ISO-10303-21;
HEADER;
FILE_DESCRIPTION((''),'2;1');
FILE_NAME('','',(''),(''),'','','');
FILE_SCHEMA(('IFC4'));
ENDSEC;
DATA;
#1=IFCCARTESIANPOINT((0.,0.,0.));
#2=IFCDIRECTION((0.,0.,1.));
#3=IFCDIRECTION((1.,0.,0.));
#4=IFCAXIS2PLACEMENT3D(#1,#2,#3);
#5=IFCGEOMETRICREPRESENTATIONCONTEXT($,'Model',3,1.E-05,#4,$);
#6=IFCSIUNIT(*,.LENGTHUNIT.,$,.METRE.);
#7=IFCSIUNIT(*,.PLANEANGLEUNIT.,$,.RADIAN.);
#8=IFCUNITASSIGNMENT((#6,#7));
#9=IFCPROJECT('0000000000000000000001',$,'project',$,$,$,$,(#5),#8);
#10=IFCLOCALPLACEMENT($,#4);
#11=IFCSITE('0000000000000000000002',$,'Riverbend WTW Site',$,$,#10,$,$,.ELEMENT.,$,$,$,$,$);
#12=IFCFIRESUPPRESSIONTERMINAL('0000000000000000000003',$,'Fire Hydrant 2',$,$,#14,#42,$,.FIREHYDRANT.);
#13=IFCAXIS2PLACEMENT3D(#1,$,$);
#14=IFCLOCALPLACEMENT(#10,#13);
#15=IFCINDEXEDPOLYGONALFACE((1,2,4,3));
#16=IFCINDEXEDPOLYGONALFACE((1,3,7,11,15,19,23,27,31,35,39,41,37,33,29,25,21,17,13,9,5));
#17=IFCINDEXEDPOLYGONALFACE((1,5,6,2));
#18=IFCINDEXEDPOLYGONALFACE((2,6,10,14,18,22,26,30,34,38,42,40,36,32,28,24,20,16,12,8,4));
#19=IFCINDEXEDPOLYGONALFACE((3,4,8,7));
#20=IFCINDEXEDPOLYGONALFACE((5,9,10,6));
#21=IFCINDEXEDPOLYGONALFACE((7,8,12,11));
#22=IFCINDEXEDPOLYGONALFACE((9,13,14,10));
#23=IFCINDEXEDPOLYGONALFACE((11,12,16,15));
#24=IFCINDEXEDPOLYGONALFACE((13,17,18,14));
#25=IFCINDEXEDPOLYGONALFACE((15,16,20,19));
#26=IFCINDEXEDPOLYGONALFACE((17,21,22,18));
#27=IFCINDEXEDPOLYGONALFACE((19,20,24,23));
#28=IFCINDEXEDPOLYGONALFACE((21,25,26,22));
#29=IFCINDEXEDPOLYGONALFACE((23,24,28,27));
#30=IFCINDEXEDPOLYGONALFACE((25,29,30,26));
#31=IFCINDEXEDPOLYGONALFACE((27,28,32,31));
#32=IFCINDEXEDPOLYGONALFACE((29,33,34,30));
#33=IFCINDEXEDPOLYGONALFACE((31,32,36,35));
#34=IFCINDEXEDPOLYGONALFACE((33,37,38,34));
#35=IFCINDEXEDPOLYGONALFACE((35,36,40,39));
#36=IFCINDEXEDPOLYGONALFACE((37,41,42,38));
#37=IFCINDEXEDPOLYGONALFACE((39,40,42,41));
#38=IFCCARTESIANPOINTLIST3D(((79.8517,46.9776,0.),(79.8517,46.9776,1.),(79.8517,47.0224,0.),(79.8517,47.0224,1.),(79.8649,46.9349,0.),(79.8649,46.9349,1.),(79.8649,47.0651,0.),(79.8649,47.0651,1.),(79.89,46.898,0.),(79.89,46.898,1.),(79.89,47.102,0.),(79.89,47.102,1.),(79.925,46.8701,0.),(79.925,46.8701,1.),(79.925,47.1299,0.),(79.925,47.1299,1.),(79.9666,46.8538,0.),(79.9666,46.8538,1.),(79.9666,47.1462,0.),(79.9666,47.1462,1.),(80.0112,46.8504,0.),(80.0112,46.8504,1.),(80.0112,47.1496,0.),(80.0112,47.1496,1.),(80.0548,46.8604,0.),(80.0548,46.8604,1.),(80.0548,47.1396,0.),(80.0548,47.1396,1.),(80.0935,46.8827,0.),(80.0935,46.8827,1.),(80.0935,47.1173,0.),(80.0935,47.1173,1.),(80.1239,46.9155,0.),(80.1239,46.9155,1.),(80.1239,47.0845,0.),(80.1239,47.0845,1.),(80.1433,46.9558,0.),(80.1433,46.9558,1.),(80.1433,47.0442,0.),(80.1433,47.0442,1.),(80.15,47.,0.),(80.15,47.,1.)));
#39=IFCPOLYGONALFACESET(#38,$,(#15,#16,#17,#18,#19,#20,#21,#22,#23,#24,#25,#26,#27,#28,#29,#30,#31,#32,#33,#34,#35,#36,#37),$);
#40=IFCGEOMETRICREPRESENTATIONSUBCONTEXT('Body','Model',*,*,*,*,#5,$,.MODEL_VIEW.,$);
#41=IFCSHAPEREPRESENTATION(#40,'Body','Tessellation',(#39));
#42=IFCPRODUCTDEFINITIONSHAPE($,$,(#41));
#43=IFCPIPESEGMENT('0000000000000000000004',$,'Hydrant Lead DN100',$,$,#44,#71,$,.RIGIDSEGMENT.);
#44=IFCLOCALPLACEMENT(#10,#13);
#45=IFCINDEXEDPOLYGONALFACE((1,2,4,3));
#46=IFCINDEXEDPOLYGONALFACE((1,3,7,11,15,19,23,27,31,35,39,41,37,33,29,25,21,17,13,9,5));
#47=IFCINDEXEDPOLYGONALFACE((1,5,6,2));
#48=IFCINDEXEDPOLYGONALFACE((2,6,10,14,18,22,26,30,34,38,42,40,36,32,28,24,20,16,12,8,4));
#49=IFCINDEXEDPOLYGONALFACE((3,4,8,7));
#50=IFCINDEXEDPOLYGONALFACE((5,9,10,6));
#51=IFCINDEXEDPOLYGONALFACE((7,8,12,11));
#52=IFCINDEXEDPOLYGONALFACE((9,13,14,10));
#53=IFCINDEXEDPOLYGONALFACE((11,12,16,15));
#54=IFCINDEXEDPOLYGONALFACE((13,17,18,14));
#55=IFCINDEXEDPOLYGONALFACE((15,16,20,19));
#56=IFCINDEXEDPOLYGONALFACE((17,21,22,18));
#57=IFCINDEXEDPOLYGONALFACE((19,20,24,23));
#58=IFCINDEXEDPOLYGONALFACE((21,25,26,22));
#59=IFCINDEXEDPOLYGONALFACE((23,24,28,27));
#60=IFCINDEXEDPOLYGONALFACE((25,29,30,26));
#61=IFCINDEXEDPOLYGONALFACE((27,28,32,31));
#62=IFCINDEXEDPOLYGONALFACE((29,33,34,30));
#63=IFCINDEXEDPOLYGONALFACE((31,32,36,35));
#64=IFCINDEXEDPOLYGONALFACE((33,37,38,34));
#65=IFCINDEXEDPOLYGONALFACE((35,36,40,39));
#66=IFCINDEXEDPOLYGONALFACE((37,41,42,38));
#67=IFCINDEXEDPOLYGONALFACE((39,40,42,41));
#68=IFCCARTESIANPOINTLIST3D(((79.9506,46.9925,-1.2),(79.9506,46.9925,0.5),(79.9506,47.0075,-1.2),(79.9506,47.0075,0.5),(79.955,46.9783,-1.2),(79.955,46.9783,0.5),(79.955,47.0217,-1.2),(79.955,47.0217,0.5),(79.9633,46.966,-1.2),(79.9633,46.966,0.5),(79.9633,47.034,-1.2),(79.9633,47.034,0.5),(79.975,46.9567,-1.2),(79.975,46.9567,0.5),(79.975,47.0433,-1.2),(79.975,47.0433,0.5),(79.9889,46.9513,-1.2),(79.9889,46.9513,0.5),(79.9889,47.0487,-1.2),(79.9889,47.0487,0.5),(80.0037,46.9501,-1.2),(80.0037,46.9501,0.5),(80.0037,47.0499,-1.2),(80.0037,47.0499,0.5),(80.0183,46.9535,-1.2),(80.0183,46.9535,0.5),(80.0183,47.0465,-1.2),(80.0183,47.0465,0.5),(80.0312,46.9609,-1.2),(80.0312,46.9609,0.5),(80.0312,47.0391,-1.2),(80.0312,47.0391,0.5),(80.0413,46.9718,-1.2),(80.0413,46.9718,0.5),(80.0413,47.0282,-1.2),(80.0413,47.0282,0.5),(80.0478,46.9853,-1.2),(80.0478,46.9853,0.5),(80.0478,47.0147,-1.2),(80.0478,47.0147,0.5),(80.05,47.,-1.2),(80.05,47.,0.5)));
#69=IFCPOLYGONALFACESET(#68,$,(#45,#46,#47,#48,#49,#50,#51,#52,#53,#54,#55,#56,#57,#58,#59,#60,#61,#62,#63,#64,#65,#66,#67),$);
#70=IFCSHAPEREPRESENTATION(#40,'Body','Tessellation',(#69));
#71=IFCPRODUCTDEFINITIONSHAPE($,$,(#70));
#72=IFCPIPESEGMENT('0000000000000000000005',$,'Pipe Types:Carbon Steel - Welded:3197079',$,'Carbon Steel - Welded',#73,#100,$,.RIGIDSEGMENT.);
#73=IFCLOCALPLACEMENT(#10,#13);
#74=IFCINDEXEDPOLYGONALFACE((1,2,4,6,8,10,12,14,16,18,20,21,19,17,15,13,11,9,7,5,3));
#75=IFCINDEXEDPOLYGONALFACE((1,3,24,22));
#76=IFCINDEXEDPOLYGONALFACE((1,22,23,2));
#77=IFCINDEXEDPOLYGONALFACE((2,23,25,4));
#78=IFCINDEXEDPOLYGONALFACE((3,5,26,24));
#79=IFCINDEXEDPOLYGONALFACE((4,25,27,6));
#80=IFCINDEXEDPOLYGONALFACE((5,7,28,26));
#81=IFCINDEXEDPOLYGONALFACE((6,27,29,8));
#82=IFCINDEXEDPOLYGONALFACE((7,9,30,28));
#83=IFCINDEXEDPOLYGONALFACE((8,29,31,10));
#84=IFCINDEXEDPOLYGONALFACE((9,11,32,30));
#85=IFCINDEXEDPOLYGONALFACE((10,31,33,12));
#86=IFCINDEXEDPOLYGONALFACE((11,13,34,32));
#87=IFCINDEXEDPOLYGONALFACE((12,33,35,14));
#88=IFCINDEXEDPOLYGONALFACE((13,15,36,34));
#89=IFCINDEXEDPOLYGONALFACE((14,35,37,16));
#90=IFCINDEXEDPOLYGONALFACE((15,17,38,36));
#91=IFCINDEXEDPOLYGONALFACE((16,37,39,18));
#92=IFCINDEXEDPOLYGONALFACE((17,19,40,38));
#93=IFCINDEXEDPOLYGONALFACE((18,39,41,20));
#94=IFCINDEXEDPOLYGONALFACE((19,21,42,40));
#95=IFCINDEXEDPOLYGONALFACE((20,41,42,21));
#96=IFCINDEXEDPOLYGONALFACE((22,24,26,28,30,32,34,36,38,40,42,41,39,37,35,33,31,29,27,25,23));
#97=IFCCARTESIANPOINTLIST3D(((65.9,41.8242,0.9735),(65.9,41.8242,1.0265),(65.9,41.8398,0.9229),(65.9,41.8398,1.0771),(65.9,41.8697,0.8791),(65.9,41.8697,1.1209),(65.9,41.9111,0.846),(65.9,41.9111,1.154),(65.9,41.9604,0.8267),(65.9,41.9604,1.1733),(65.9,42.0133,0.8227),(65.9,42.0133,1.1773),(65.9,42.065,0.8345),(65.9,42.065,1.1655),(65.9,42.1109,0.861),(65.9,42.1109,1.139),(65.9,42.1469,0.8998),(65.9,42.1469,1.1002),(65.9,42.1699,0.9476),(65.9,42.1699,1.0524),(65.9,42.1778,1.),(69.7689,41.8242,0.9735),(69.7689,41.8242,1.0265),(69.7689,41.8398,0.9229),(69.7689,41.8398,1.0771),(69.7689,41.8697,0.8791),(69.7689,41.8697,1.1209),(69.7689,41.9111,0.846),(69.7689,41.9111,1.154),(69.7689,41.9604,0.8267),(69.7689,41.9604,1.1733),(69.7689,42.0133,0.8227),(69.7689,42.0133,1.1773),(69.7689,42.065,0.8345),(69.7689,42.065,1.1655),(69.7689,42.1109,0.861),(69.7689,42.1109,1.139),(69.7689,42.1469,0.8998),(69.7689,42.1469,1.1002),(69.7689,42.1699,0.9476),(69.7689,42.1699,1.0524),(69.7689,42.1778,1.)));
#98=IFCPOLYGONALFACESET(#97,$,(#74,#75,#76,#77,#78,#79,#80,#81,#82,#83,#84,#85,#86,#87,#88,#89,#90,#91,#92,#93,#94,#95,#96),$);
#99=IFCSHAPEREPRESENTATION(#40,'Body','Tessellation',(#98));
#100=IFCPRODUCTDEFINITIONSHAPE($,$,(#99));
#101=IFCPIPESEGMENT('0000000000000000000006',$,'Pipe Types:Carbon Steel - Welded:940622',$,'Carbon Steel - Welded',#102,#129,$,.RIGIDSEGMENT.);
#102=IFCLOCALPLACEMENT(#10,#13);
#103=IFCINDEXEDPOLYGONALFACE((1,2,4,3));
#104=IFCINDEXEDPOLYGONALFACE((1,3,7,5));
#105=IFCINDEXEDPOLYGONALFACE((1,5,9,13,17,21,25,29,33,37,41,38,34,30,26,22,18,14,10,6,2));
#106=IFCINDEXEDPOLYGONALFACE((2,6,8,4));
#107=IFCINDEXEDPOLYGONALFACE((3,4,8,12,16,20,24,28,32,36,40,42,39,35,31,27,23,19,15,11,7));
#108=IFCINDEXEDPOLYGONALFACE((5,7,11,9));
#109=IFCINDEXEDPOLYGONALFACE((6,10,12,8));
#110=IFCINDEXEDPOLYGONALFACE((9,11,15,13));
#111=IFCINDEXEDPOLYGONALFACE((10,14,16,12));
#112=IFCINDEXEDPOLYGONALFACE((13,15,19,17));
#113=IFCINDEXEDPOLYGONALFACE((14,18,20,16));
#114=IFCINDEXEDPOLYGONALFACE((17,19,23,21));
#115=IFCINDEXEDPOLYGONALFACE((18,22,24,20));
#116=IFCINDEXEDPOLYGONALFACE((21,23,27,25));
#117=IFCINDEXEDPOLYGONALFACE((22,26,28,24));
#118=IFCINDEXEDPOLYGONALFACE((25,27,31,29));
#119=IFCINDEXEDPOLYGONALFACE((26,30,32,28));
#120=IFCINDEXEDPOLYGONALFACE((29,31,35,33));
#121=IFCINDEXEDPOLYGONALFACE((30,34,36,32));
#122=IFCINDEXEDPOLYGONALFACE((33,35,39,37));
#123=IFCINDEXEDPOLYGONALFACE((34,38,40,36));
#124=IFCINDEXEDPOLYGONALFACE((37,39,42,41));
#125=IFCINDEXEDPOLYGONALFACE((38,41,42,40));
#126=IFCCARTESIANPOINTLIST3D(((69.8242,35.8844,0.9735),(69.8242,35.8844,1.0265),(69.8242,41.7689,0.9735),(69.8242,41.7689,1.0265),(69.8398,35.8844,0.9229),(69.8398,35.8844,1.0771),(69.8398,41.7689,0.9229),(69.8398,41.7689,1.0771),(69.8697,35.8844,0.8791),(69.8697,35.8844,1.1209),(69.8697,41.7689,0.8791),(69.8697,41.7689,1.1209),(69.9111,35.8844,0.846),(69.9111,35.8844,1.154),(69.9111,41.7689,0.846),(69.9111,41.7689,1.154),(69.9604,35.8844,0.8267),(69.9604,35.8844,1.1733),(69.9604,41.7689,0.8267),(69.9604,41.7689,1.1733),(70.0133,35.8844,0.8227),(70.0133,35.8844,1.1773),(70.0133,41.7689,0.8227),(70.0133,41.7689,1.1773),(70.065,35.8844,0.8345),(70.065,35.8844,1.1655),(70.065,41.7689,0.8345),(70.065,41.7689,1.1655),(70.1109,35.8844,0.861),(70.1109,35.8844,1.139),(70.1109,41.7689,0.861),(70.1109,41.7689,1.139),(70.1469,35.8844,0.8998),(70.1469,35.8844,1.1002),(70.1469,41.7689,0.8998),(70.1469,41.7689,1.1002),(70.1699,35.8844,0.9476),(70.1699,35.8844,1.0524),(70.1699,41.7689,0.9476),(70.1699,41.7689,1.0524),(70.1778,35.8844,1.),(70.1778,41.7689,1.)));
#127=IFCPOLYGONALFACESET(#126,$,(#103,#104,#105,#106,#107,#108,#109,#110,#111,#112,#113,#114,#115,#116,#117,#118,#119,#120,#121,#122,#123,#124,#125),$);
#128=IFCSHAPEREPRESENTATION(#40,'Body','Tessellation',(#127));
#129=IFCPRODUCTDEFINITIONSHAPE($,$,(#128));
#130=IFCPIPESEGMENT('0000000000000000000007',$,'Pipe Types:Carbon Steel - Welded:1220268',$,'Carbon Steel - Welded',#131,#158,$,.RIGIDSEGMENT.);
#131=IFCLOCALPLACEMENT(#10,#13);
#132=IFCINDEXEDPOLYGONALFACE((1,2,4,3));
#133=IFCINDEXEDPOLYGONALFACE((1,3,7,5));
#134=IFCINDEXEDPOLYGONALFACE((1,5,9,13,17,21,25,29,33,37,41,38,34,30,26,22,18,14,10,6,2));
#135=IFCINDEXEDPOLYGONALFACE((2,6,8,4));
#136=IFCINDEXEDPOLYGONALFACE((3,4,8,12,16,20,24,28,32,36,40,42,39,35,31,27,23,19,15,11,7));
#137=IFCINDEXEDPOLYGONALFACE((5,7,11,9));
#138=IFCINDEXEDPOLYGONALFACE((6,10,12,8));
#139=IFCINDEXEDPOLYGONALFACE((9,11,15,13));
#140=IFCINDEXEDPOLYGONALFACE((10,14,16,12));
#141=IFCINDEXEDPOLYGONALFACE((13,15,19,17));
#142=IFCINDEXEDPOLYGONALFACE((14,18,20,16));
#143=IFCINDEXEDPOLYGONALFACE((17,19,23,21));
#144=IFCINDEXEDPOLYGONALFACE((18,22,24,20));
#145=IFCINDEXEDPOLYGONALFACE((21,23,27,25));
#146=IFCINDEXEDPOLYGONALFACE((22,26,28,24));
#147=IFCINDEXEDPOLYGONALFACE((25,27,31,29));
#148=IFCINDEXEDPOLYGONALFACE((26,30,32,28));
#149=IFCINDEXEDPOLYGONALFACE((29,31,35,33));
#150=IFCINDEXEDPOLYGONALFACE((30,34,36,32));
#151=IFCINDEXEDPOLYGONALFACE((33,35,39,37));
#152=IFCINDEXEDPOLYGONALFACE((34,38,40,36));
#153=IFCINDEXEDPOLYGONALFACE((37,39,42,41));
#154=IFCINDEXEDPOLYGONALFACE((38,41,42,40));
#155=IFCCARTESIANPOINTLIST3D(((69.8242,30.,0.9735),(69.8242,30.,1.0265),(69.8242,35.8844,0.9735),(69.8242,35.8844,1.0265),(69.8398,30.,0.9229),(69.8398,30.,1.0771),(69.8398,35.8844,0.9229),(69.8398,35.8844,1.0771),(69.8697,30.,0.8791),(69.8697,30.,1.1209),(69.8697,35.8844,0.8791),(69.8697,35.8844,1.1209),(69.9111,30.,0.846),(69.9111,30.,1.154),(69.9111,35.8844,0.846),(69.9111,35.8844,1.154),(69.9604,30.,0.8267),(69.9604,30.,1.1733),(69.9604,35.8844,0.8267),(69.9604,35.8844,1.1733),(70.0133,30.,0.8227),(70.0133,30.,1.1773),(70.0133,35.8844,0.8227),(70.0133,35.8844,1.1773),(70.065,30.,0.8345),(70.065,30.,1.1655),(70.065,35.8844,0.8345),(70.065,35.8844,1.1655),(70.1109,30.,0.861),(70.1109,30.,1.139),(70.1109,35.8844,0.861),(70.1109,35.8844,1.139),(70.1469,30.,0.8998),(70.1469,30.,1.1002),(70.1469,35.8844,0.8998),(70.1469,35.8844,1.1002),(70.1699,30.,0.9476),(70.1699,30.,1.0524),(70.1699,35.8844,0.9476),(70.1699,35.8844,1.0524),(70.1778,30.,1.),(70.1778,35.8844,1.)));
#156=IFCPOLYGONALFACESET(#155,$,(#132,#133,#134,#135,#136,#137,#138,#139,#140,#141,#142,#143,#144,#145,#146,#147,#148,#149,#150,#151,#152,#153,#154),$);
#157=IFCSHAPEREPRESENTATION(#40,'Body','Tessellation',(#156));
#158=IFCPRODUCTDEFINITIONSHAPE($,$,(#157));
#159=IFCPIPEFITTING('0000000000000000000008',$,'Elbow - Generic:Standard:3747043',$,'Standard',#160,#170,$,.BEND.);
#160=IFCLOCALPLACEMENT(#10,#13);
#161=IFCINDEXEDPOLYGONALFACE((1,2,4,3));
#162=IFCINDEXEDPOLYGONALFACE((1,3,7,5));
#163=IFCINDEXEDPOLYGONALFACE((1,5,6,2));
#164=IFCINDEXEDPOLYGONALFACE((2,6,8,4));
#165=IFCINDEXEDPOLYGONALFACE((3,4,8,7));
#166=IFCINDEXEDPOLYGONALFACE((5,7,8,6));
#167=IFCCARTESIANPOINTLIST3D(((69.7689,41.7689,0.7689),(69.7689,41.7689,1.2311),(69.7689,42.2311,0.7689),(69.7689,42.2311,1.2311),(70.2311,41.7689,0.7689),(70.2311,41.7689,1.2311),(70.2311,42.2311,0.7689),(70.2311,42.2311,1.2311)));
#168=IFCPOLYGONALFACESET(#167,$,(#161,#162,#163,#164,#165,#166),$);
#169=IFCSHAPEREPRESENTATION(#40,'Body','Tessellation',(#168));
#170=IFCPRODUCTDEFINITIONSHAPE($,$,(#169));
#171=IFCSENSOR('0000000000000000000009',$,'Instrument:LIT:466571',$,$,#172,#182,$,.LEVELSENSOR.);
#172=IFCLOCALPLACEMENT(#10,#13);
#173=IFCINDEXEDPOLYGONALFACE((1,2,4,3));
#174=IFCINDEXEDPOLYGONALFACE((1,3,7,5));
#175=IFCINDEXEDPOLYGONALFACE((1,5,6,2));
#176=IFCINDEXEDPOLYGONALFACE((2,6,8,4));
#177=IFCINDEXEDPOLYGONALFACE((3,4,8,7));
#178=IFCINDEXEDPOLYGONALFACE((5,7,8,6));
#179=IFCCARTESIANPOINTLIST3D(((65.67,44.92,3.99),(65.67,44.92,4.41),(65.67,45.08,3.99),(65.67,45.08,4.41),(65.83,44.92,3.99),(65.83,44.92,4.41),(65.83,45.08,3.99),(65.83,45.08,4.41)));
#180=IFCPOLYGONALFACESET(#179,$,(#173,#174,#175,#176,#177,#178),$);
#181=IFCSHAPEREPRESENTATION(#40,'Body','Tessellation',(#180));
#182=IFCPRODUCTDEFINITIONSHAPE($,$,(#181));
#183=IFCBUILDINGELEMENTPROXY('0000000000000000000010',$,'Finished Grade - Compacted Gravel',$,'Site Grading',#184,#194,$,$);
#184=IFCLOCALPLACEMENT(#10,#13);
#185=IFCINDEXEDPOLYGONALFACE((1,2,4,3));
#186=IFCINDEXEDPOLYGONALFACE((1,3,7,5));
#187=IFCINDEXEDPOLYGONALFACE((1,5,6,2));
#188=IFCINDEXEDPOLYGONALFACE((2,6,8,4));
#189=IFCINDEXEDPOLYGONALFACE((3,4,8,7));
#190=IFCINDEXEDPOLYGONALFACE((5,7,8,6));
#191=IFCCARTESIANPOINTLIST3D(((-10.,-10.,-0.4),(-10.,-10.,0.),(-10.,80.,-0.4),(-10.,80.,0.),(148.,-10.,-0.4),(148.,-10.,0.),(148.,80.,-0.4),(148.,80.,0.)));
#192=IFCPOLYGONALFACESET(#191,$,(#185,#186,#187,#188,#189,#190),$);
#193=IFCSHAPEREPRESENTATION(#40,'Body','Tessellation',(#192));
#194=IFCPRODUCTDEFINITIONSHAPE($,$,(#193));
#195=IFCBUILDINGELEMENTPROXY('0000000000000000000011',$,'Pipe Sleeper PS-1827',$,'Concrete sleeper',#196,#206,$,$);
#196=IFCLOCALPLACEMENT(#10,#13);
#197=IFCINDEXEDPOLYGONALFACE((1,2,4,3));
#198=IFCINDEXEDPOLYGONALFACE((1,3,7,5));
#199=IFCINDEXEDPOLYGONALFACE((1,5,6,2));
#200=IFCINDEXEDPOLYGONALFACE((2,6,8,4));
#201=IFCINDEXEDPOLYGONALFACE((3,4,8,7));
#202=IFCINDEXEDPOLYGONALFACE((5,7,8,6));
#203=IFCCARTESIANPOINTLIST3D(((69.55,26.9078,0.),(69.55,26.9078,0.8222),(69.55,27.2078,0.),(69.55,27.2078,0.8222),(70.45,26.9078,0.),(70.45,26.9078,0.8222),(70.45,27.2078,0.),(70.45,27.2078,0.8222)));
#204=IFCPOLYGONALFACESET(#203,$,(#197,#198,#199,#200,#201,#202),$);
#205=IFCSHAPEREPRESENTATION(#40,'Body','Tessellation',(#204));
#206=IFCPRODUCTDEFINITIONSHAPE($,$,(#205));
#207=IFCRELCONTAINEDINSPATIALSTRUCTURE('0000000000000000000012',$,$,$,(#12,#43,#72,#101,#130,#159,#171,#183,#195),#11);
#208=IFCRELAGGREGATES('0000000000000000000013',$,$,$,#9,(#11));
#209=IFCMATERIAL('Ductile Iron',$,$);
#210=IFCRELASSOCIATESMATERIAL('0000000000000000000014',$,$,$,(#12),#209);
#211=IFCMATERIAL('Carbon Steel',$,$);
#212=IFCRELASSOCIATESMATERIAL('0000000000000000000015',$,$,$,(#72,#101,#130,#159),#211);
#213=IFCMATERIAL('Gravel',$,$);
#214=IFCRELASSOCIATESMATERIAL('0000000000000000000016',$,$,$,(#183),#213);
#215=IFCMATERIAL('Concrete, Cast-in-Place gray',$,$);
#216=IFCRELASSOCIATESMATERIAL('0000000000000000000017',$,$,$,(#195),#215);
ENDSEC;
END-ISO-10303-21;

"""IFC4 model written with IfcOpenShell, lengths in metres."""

from ifc_helpers import new_model, si_unit, frame, origin_with_axes, origin_2d, place, context, subcontext, project, spatial, rectangle, circle, extrude, material, element, save


model = new_model("IFC4")

# Units and contexts
model_context = context("Model", 3, precision=1e-05, world=origin_with_axes())
body_context = subcontext(model_context, "Body", "Model", "MODEL_VIEW")
ifc_project = project(units=[si_unit("LENGTHUNIT", "METRE"), si_unit("PLANEANGLEUNIT", "RADIAN")], contexts=[model_context])

# Site
site_placement = place(None, origin_with_axes())
site = spatial("IfcSite", under=ifc_project, at=site_placement, Name="Riverbend WTW Site", CompositionType="ELEMENT")

# Shared definitions
ifc_material_1 = material(Name="Concrete, Cast-in-Place gray")

# Shared definitions
ifc_material_2 = material(Name="Ductile Iron")

# Fire suppression terminal
fire_suppression_terminal_1_placement = place(None, frame((80.0, 47.0, 0.0), z_axis=(0.0, 0.0, 1.0), x_axis=(1.0, 0.0, 0.0)))
element("IfcFireSuppressionTerminal", 1, at=fire_suppression_terminal_1_placement, inside=site, material=ifc_material_2, Name="Fire Hydrant 2", PredefinedType="FIREHYDRANT", context=body_context, shape_type="SweptSolid", body=[
    extrude(circle(Radius=0.15, at=origin_2d()), origin_with_axes(), (0.0, 0.0, 1.0), 1.0),
])

# Pipe segments
pipe_segment_1_placement = place(None, frame((80.0, 47.0, -1.2), z_axis=(0.0, 0.0, 1.0), x_axis=(1.0, 0.0, 0.0)))
element("IfcPipeSegment", 2, at=pipe_segment_1_placement, inside=site, Name="Hydrant Lead DN100", PredefinedType="RIGIDSEGMENT", context=body_context, shape_type="SweptSolid", body=[
    extrude(circle(Radius=0.05, at=origin_2d()), origin_with_axes(), (0.0, 0.0, 1.0), 1.7),
])
ifc_material_3 = material(Name="Carbon Steel")
pipe_segment_2_placement = place(None, frame((65.9, 42.0, 1.0), z_axis=(0.0, 0.0, 1.0), x_axis=(1.0, 0.0, 0.0)))
element("IfcPipeSegment", 3, at=pipe_segment_2_placement, inside=site, material=ifc_material_3, Name="Pipe Types:Carbon Steel - Welded:3197079", ObjectType="Carbon Steel - Welded", PredefinedType="RIGIDSEGMENT", context=body_context, shape_type="SweptSolid", body=[
    extrude(circle(Radius=0.1778, at=origin_2d()), frame((0.0, 0.0, 0.0), z_axis=(1.0, 0.0, 0.0), x_axis=(0.0, 1.0, 0.0)), (0.0, 0.0, 1.0), 3.8689),
])
pipe_segment_3_placement = place(None, frame((70.0, 41.7689, 1.0), z_axis=(0.0, 0.0, 1.0), x_axis=(1.0, 0.0, 0.0)))
element("IfcPipeSegment", 4, at=pipe_segment_3_placement, inside=site, material=ifc_material_3, Name="Pipe Types:Carbon Steel - Welded:940622", ObjectType="Carbon Steel - Welded", PredefinedType="RIGIDSEGMENT", context=body_context, shape_type="SweptSolid", body=[
    extrude(circle(Radius=0.1778, at=origin_2d()), frame((0.0, 0.0, 0.0), z_axis=(0.0, -1.0, 0.0), x_axis=(1.0, 0.0, 0.0)), (0.0, 0.0, 1.0), 5.8844),
])
pipe_segment_4_placement = place(None, frame((70.0, 35.8844, 1.0), z_axis=(0.0, 0.0, 1.0), x_axis=(1.0, 0.0, 0.0)))
element("IfcPipeSegment", 5, at=pipe_segment_4_placement, inside=site, material=ifc_material_3, Name="Pipe Types:Carbon Steel - Welded:1220268", ObjectType="Carbon Steel - Welded", PredefinedType="RIGIDSEGMENT", context=body_context, shape_type="SweptSolid", body=[
    extrude(circle(Radius=0.1778, at=origin_2d()), frame((0.0, 0.0, 0.0), z_axis=(0.0, -1.0, 0.0), x_axis=(1.0, 0.0, 0.0)), (0.0, 0.0, 1.0), 5.8844),
])

# Pipe fitting
pipe_fitting_placement = place(None, frame((70.0, 42.0, 1.0), z_axis=(0.0, 0.0, 1.0), x_axis=(1.0, 0.0, 0.0)))
element("IfcPipeFitting", 6, at=pipe_fitting_placement, inside=site, material=ifc_material_3, Name="Elbow - Generic:Standard:3747043", ObjectType="Standard", PredefinedType="BEND", context=body_context, shape_type="SweptSolid", body=[
    extrude(rectangle(XDim=0.4623, YDim=0.4623, at=origin_2d()), frame((0.0, 0.0, -0.2311), z_axis=(0.0, 0.0, 1.0), x_axis=(1.0, 0.0, 0.0)), (0.0, 0.0, 1.0), 0.4623),
])

# Sensor
sensor_placement = place(None, frame((65.75, 45.0, 4.2), z_axis=(0.0, 0.0, 1.0), x_axis=(1.0, 0.0, 0.0)))
element("IfcSensor", 7, at=sensor_placement, inside=site, Name="Instrument:LIT:466571", PredefinedType="LEVELSENSOR", context=body_context, shape_type="SweptSolid", body=[
    extrude(rectangle(XDim=0.16, YDim=0.16, at=origin_2d()), frame((0.0, 0.0, -0.21), z_axis=(0.0, 0.0, 1.0), x_axis=(1.0, 0.0, 0.0)), (0.0, 0.0, 1.0), 0.42),
])

# Building element proxies
ifc_material_4 = material(Name="Gravel")
proxy_1_placement = place(None, frame((69.0, 35.0, -0.2), z_axis=(0.0, 0.0, 1.0), x_axis=(1.0, 0.0, 0.0)))
element("IfcBuildingElementProxy", 8, at=proxy_1_placement, inside=site, material=ifc_material_4, Name="Finished Grade - Compacted Gravel", ObjectType="Site Grading", context=body_context, shape_type="SweptSolid", body=[
    extrude(rectangle(XDim=158.0, YDim=90.0, at=origin_2d()), frame((0.0, 0.0, -0.2), z_axis=(0.0, 0.0, 1.0), x_axis=(1.0, 0.0, 0.0)), (0.0, 0.0, 1.0), 0.4),
])
proxy_2_placement = place(None, frame((70.0, 27.0578, 0.4111), z_axis=(0.0, 0.0, 1.0), x_axis=(1.0, 0.0, 0.0)))
element("IfcBuildingElementProxy", 9, at=proxy_2_placement, inside=site, material=ifc_material_1, Name="Pipe Sleeper PS-1827", ObjectType="Concrete sleeper", context=body_context, shape_type="SweptSolid", body=[
    extrude(rectangle(XDim=0.9, YDim=0.3, at=origin_2d()), frame((0.0, 0.0, -0.4111), z_axis=(0.0, 0.0, 1.0), x_axis=(1.0, 0.0, 0.0)), (0.0, 0.0, 1.0), 0.8222),
])

save(model, "model.ifc")
